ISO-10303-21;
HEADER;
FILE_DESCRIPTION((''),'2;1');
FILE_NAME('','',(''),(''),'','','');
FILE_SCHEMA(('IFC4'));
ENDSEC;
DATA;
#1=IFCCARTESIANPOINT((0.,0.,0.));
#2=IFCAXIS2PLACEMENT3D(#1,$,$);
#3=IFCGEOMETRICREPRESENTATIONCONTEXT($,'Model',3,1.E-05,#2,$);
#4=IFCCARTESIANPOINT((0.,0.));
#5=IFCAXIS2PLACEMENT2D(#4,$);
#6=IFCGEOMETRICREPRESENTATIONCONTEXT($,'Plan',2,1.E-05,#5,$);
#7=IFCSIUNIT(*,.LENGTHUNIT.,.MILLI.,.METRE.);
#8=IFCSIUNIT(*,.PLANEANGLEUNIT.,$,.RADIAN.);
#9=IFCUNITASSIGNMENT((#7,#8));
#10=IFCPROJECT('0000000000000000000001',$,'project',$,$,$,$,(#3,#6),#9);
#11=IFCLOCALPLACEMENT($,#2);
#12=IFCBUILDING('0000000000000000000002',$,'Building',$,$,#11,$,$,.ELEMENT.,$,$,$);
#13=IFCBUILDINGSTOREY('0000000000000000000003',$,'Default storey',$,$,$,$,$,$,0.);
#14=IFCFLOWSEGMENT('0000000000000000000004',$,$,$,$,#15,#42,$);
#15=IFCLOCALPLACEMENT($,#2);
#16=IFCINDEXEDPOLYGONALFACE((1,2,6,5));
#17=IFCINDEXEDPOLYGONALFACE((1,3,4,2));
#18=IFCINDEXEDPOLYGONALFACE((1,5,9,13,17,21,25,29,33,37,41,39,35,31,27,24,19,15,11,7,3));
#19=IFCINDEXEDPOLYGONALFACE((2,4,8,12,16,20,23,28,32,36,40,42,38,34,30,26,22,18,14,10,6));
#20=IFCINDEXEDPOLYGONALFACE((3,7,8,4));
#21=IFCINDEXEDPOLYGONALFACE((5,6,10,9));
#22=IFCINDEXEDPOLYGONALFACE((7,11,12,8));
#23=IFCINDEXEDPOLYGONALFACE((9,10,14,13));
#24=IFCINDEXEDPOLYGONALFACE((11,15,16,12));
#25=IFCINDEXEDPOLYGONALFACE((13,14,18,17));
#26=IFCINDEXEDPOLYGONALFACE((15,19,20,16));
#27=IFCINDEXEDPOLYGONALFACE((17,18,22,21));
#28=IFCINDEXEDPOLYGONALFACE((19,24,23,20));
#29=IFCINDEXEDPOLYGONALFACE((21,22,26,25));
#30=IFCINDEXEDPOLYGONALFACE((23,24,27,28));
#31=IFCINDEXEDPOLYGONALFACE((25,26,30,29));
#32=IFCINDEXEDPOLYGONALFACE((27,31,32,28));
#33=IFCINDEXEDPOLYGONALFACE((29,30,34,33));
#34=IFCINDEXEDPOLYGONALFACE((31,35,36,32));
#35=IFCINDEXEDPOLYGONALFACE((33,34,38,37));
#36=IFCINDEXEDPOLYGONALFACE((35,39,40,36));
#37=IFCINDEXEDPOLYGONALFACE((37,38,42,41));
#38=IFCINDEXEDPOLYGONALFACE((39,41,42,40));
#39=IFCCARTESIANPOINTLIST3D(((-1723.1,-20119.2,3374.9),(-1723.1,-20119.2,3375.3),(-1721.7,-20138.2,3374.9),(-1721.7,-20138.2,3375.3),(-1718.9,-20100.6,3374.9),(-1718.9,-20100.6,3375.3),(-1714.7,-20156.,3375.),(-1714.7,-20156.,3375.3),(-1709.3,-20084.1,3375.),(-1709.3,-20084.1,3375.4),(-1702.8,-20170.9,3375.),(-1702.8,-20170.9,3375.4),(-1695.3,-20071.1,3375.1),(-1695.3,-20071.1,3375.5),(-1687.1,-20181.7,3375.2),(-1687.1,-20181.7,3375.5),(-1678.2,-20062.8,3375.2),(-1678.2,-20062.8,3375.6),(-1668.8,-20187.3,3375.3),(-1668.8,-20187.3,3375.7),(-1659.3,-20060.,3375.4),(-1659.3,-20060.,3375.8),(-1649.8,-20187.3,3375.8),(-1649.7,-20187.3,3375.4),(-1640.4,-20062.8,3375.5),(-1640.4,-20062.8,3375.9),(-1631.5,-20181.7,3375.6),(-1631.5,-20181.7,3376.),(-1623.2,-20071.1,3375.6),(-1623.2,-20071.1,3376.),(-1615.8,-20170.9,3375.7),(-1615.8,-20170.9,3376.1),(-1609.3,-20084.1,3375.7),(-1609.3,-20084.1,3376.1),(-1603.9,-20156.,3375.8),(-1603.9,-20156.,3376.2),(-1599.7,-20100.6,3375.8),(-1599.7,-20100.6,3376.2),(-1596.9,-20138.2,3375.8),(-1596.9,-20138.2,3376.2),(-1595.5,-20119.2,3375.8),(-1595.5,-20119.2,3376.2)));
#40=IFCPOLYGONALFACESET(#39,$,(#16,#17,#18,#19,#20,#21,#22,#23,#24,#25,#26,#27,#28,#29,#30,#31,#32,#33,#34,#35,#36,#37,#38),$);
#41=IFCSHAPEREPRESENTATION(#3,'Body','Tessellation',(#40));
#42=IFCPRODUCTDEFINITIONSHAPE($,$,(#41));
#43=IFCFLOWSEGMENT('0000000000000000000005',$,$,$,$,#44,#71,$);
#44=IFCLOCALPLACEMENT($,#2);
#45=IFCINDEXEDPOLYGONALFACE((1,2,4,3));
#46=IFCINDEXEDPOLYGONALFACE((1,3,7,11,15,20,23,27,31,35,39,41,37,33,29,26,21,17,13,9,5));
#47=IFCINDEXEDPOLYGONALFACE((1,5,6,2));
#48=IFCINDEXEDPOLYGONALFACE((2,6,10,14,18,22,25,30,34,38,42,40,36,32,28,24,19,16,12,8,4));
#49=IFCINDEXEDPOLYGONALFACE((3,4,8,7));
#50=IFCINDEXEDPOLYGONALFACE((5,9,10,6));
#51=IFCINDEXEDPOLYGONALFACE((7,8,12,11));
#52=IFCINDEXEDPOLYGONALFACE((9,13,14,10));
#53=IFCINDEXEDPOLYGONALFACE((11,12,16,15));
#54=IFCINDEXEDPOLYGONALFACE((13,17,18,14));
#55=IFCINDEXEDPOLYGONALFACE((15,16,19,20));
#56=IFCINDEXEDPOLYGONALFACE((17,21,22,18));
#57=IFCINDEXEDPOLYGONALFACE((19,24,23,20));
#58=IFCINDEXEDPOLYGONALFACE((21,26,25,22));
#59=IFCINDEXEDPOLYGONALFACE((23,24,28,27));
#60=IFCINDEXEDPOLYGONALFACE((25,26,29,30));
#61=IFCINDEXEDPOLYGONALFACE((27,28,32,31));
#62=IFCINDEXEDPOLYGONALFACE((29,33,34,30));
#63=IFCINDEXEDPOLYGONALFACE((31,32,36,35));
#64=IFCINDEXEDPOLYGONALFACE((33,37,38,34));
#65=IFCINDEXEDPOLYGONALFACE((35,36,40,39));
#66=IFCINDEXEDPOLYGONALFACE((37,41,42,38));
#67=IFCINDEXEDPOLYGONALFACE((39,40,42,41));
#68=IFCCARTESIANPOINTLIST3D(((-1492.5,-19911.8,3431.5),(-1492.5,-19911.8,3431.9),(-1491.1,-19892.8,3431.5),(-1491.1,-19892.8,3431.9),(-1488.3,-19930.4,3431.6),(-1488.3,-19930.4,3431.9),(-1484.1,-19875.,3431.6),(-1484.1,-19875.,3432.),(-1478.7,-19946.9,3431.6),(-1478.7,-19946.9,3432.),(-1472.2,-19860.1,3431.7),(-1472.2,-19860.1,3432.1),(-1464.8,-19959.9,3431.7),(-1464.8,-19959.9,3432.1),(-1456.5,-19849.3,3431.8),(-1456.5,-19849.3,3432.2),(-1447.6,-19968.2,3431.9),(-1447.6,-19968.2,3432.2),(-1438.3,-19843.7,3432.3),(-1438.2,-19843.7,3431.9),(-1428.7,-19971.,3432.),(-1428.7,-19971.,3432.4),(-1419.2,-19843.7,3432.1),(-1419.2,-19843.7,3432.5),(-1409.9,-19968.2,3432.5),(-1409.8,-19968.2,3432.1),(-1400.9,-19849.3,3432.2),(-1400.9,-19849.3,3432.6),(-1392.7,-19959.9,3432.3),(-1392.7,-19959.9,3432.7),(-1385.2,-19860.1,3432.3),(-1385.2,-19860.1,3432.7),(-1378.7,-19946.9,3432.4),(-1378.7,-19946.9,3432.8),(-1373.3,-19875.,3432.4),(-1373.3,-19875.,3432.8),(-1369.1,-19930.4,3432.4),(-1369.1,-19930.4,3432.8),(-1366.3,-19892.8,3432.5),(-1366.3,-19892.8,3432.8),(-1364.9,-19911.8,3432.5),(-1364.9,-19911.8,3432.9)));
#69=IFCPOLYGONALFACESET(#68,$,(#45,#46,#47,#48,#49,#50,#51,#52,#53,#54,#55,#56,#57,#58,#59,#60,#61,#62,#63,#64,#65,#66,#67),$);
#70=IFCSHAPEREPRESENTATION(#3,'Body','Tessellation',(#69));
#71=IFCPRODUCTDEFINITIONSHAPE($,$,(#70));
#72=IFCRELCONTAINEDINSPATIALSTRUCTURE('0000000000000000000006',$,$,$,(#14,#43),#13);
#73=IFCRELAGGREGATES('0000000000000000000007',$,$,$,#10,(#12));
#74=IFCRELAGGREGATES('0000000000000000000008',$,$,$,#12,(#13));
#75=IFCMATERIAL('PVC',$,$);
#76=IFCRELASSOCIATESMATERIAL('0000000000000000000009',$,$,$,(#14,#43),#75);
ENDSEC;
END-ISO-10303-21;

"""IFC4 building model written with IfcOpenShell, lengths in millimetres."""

from ifc_helpers import new_model, si_unit, frame, origin, origin_2d, place, context, project, spatial, circle, extrude, material, element, save


model = new_model("IFC4")

# Units and contexts
model_context = context("Model", 3, precision=1e-05, world=origin())
plan_context = context("Plan", 2, precision=1e-05, world=origin_2d())
ifc_project = project(units=[si_unit("LENGTHUNIT", "METRE", prefix="MILLI"), si_unit("PLANEANGLEUNIT", "RADIAN")], contexts=[model_context, plan_context])

# Building, storey
placement = place(None, origin())
building = spatial("IfcBuilding", under=ifc_project, at=placement, Name="Building", CompositionType="ELEMENT")
storey = spatial("IfcBuildingStorey", under=building, Name="Default storey", Elevation=0.0)

# Flow segments
ifc_material_1 = material(Name="PVC")
element("IfcFlowSegment", 1, at=placement, inside=storey, material=ifc_material_1, context=model_context, shape_type="SweptSolid", body=[
    extrude(circle(Radius=64.0, at=origin_2d()), frame((-1659.3, -20124.0, 3375.4), z_axis=(-0.002892, 0.0, 0.387527), x_axis=(0.0, 2.891989, 0.0)), (0.0, 0.0, 1.0), 0.4),
])
element("IfcFlowSegment", 2, at=placement, inside=storey, material=ifc_material_1, context=model_context, shape_type="SweptSolid", body=[
    extrude(circle(Radius=64.0, at=origin_2d()), frame((-1428.7, -19907.0, 3432.4), z_axis=(0.002889, 0.0, -0.390026), x_axis=(0.0, -2.889084, 0.0)), (0.0, 0.0, 1.0), 0.4),
])

save(model, "model.ifc")
